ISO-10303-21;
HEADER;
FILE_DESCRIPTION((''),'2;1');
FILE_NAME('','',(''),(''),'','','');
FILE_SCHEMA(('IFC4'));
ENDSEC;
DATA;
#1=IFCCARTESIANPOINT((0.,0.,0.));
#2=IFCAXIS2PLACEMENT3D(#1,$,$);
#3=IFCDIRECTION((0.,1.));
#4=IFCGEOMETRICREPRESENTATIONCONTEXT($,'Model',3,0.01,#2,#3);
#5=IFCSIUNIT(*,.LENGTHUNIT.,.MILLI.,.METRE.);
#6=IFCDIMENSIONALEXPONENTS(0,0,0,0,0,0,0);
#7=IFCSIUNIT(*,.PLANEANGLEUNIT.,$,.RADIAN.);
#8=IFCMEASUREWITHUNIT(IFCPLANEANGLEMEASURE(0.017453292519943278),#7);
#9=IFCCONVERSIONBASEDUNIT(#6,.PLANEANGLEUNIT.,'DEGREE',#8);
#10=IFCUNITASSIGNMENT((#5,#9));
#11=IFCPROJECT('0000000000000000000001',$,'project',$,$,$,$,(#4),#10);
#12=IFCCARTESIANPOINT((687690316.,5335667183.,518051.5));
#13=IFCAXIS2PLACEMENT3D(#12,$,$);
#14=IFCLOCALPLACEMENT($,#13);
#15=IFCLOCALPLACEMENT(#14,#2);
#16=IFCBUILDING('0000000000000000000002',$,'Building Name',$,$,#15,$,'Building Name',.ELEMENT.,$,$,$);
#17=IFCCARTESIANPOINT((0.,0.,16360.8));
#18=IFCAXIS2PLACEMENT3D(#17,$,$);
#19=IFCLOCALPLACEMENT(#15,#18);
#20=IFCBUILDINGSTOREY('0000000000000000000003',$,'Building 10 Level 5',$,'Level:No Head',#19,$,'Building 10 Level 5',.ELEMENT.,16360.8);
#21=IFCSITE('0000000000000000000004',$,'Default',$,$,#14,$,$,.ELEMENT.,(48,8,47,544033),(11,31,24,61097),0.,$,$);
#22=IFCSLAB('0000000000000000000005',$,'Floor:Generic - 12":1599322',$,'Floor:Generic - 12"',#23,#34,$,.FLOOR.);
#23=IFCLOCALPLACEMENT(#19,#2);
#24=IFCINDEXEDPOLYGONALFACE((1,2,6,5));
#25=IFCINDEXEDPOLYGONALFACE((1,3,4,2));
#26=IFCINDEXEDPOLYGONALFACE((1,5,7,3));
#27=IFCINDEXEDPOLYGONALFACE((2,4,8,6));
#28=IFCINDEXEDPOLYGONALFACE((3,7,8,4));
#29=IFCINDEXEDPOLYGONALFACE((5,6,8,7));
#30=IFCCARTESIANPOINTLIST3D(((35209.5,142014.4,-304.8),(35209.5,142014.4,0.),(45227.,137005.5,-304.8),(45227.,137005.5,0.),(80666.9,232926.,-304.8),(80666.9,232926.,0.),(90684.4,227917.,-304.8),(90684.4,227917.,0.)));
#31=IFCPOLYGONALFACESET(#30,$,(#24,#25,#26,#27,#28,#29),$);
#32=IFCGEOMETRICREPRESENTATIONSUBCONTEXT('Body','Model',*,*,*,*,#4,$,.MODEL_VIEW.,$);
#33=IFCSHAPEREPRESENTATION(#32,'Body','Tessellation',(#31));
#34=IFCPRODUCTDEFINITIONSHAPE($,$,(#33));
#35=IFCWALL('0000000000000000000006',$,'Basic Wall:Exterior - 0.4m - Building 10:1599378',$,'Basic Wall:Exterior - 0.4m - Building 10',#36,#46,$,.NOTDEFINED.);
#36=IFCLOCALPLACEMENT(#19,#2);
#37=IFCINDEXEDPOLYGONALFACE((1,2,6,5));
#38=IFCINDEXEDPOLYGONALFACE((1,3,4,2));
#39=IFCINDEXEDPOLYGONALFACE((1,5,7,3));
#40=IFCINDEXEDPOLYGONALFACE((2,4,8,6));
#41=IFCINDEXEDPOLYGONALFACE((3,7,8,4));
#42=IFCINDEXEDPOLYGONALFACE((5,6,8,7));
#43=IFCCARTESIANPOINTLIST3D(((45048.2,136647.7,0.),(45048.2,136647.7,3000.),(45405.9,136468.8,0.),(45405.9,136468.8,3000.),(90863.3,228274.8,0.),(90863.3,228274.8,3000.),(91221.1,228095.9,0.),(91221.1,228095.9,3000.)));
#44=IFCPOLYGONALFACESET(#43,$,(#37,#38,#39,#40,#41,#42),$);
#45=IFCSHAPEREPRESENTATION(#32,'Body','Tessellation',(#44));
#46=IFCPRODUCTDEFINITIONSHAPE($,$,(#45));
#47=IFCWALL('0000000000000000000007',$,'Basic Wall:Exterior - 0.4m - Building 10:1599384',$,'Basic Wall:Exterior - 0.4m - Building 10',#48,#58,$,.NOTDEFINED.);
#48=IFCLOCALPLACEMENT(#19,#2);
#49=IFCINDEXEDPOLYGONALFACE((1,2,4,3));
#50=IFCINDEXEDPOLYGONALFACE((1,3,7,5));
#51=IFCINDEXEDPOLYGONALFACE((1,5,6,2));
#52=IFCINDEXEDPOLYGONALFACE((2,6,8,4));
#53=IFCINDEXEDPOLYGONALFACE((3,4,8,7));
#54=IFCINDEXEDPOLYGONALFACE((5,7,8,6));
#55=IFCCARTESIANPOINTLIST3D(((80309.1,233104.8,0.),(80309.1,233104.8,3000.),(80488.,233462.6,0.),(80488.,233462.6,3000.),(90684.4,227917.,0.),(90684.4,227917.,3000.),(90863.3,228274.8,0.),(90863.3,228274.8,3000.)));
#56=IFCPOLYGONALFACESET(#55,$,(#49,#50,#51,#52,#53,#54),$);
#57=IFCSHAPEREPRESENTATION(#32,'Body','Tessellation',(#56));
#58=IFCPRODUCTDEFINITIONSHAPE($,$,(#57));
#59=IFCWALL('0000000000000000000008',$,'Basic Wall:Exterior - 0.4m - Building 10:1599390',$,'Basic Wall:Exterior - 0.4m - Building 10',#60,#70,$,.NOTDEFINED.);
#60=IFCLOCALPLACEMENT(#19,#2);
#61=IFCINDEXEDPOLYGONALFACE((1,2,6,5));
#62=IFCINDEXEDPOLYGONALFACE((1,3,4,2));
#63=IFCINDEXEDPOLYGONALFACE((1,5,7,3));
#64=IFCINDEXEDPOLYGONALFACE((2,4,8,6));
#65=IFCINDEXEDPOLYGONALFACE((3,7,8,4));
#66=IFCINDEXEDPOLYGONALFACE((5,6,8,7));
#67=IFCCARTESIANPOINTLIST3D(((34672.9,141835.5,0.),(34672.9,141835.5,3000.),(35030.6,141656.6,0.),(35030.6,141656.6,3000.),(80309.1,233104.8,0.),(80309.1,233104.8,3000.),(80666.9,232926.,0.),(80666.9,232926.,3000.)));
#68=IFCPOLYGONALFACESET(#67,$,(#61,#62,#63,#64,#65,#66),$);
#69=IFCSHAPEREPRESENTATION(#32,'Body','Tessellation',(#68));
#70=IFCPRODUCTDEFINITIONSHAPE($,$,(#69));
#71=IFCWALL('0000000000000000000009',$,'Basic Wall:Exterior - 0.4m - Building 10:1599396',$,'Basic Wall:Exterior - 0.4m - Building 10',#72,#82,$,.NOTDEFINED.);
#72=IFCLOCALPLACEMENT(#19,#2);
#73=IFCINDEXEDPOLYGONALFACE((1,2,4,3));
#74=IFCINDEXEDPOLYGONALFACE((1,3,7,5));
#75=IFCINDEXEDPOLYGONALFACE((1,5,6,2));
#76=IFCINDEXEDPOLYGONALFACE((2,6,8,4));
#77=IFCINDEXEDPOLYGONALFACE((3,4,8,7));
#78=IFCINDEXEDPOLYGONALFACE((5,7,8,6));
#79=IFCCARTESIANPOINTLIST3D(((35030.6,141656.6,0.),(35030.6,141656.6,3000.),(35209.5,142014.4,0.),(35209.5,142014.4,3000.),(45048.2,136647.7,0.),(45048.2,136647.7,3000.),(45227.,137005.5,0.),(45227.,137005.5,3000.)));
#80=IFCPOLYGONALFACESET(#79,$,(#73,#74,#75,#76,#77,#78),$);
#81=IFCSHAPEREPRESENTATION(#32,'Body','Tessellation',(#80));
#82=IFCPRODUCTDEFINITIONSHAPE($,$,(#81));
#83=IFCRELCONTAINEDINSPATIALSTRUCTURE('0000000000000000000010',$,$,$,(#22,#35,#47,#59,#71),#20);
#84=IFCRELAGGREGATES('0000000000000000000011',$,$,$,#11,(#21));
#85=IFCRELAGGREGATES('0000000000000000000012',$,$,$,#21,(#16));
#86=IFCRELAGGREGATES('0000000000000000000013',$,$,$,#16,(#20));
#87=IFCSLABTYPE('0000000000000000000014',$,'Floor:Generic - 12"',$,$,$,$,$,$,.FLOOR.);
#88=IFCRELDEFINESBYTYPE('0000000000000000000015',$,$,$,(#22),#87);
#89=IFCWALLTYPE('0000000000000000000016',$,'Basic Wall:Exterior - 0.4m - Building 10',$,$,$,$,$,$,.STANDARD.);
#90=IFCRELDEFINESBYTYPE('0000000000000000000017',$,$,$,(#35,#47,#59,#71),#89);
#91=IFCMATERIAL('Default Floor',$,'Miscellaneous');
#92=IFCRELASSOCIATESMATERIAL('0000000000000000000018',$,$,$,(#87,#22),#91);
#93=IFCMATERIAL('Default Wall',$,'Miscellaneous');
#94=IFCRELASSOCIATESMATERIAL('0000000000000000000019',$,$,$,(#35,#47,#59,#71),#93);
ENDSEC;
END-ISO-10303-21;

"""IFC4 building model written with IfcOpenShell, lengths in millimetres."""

from ifc_helpers import new_model, entity, si_unit, converted_unit, direction, frame, origin, place, context, subcontext, project, spatial, indexed_curve, outline, extrude, material, type_object, element, save


model = new_model("IFC4")

# Units and contexts
model_context = context("Model", 3, precision=0.01, world=origin(), true_north=direction((0.0, 1.0)))
body_context = subcontext(model_context, "Body", "Model", "MODEL_VIEW")
ifc_project = project(units=[si_unit("LENGTHUNIT", "METRE", prefix="MILLI"), converted_unit("PLANEANGLEUNIT", "DEGREE", entity("IfcPlaneAngleMeasure", 0.017453292519943278), si_unit("PLANEANGLEUNIT", "RADIAN"), dimensions=[0, 0, 0, 0, 0, 0, 0])], contexts=[model_context])

# Site, building, storey
site_placement = place(None, frame((687690316.0, 5335667183.0, 518051.5)))
site = spatial("IfcSite", under=ifc_project, at=site_placement, Name="Default", CompositionType="ELEMENT", RefLatitude=(48, 8, 47, 544033), RefLongitude=(11, 31, 24, 61097), RefElevation=0.0)
building_placement = place(site_placement, origin())
building = spatial("IfcBuilding", under=site, at=building_placement, Name="Building Name", LongName="Building Name", CompositionType="ELEMENT")
storey_placement = place(building_placement, frame((0.0, 0.0, 16360.8)))
storey = spatial("IfcBuildingStorey", under=building, at=storey_placement, Name="Building 10 Level 5", ObjectType="Level:No Head", LongName="Building 10 Level 5", CompositionType="ELEMENT", Elevation=16360.8)

# Slab
ifc_material_1 = material(Name="Default Floor", Category="Miscellaneous")
slab_type = type_object("IfcSlabType", Name="Floor:Generic - 12\"", PredefinedType="FLOOR", material=ifc_material_1)
slab_placement = place(storey_placement, origin())
element("IfcSlab", 1, at=slab_placement, inside=storey, type_object=slab_type, material=ifc_material_1, Name="Floor:Generic - 12\":1599322", ObjectType="Floor:Generic - 12\"", PredefinedType="FLOOR", context=body_context, shape_type="SweptSolid", body=[
    extrude(outline(indexed_curve([(-50821.4, -5600.0), (50821.4, -5600.0), (50821.4, 5600.0), (-50821.4, 5600.0), (-50821.4, -5600.0)], self_intersect=False)), frame((62947.0, 184965.7, 0.0), z_axis=(0.0, 0.0, -1.0), x_axis=(-0.447226, -0.894421, 0.0)), (0.0, 0.0, 1.0), 304.8),
])

# Walls
ifc_material_2 = material(Name="Default Wall", Category="Miscellaneous")
wall_type = type_object("IfcWallType", Name="Basic Wall:Exterior - 0.4m - Building 10", PredefinedType="STANDARD")
wall_1_placement = place(storey_placement, frame((45227.0, 136558.3, 0.0), z_axis=(0.0, 0.0, 1.0), x_axis=(0.447226, 0.894421, 0.0)))
element("IfcWall", 2, at=wall_1_placement, inside=storey, type_object=wall_type, material=ifc_material_2, Name="Basic Wall:Exterior - 0.4m - Building 10:1599378", ObjectType="Basic Wall:Exterior - 0.4m - Building 10", PredefinedType="NOTDEFINED", context=body_context, shape_type="SweptSolid", body=[
    extrude(outline(indexed_curve([(102442.9, 200.0), (0.0, 200.0), (0.0, -200.0), (102442.9, -200.0), (102442.9, 200.0)], self_intersect=False)), origin(), (0.0, 0.0, 1.0), 3000.0),
])
wall_2_placement = place(storey_placement, frame((90773.8, 228095.9, 0.0), z_axis=(0.0, 0.0, 1.0), x_axis=(-0.894421, 0.447226, 0.0)))
element("IfcWall", 3, at=wall_2_placement, inside=storey, type_object=wall_type, material=ifc_material_2, Name="Basic Wall:Exterior - 0.4m - Building 10:1599384", ObjectType="Basic Wall:Exterior - 0.4m - Building 10", PredefinedType="NOTDEFINED", context=body_context, shape_type="SweptSolid", body=[
    extrude(outline(indexed_curve([(11600.0, 200.0), (0.0, 200.0), (0.0, -200.0), (11600.0, -200.0), (11600.0, 200.0)], self_intersect=False)), origin(), (0.0, 0.0, 1.0), 3000.0),
])
wall_3_placement = place(storey_placement, frame((80488.0, 233015.4, 0.0), z_axis=(0.0, 0.0, 1.0), x_axis=(-0.447226, -0.894421, 0.0)))
element("IfcWall", 4, at=wall_3_placement, inside=storey, type_object=wall_type, material=ifc_material_2, Name="Basic Wall:Exterior - 0.4m - Building 10:1599390", ObjectType="Basic Wall:Exterior - 0.4m - Building 10", PredefinedType="NOTDEFINED", context=body_context, shape_type="SweptSolid", body=[
    extrude(outline(indexed_curve([(102042.9, 200.0), (0.0, 200.0), (0.0, -200.0), (102042.9, -200.0), (102042.9, 200.0)], self_intersect=False)), origin(), (0.0, 0.0, 1.0), 3000.0),
])
wall_4_placement = place(storey_placement, frame((35120.1, 141835.5, 0.0), z_axis=(0.0, 0.0, 1.0), x_axis=(0.894421, -0.447226, 0.0)))
element("IfcWall", 5, at=wall_4_placement, inside=storey, type_object=wall_type, material=ifc_material_2, Name="Basic Wall:Exterior - 0.4m - Building 10:1599396", ObjectType="Basic Wall:Exterior - 0.4m - Building 10", PredefinedType="NOTDEFINED", context=body_context, shape_type="SweptSolid", body=[
    extrude(outline(indexed_curve([(11200.0, 200.0), (0.0, 200.0), (0.0, -200.0), (11200.0, -200.0), (11200.0, 200.0)], self_intersect=False)), origin(), (0.0, 0.0, 1.0), 3000.0),
])

save(model, "model.ifc")
